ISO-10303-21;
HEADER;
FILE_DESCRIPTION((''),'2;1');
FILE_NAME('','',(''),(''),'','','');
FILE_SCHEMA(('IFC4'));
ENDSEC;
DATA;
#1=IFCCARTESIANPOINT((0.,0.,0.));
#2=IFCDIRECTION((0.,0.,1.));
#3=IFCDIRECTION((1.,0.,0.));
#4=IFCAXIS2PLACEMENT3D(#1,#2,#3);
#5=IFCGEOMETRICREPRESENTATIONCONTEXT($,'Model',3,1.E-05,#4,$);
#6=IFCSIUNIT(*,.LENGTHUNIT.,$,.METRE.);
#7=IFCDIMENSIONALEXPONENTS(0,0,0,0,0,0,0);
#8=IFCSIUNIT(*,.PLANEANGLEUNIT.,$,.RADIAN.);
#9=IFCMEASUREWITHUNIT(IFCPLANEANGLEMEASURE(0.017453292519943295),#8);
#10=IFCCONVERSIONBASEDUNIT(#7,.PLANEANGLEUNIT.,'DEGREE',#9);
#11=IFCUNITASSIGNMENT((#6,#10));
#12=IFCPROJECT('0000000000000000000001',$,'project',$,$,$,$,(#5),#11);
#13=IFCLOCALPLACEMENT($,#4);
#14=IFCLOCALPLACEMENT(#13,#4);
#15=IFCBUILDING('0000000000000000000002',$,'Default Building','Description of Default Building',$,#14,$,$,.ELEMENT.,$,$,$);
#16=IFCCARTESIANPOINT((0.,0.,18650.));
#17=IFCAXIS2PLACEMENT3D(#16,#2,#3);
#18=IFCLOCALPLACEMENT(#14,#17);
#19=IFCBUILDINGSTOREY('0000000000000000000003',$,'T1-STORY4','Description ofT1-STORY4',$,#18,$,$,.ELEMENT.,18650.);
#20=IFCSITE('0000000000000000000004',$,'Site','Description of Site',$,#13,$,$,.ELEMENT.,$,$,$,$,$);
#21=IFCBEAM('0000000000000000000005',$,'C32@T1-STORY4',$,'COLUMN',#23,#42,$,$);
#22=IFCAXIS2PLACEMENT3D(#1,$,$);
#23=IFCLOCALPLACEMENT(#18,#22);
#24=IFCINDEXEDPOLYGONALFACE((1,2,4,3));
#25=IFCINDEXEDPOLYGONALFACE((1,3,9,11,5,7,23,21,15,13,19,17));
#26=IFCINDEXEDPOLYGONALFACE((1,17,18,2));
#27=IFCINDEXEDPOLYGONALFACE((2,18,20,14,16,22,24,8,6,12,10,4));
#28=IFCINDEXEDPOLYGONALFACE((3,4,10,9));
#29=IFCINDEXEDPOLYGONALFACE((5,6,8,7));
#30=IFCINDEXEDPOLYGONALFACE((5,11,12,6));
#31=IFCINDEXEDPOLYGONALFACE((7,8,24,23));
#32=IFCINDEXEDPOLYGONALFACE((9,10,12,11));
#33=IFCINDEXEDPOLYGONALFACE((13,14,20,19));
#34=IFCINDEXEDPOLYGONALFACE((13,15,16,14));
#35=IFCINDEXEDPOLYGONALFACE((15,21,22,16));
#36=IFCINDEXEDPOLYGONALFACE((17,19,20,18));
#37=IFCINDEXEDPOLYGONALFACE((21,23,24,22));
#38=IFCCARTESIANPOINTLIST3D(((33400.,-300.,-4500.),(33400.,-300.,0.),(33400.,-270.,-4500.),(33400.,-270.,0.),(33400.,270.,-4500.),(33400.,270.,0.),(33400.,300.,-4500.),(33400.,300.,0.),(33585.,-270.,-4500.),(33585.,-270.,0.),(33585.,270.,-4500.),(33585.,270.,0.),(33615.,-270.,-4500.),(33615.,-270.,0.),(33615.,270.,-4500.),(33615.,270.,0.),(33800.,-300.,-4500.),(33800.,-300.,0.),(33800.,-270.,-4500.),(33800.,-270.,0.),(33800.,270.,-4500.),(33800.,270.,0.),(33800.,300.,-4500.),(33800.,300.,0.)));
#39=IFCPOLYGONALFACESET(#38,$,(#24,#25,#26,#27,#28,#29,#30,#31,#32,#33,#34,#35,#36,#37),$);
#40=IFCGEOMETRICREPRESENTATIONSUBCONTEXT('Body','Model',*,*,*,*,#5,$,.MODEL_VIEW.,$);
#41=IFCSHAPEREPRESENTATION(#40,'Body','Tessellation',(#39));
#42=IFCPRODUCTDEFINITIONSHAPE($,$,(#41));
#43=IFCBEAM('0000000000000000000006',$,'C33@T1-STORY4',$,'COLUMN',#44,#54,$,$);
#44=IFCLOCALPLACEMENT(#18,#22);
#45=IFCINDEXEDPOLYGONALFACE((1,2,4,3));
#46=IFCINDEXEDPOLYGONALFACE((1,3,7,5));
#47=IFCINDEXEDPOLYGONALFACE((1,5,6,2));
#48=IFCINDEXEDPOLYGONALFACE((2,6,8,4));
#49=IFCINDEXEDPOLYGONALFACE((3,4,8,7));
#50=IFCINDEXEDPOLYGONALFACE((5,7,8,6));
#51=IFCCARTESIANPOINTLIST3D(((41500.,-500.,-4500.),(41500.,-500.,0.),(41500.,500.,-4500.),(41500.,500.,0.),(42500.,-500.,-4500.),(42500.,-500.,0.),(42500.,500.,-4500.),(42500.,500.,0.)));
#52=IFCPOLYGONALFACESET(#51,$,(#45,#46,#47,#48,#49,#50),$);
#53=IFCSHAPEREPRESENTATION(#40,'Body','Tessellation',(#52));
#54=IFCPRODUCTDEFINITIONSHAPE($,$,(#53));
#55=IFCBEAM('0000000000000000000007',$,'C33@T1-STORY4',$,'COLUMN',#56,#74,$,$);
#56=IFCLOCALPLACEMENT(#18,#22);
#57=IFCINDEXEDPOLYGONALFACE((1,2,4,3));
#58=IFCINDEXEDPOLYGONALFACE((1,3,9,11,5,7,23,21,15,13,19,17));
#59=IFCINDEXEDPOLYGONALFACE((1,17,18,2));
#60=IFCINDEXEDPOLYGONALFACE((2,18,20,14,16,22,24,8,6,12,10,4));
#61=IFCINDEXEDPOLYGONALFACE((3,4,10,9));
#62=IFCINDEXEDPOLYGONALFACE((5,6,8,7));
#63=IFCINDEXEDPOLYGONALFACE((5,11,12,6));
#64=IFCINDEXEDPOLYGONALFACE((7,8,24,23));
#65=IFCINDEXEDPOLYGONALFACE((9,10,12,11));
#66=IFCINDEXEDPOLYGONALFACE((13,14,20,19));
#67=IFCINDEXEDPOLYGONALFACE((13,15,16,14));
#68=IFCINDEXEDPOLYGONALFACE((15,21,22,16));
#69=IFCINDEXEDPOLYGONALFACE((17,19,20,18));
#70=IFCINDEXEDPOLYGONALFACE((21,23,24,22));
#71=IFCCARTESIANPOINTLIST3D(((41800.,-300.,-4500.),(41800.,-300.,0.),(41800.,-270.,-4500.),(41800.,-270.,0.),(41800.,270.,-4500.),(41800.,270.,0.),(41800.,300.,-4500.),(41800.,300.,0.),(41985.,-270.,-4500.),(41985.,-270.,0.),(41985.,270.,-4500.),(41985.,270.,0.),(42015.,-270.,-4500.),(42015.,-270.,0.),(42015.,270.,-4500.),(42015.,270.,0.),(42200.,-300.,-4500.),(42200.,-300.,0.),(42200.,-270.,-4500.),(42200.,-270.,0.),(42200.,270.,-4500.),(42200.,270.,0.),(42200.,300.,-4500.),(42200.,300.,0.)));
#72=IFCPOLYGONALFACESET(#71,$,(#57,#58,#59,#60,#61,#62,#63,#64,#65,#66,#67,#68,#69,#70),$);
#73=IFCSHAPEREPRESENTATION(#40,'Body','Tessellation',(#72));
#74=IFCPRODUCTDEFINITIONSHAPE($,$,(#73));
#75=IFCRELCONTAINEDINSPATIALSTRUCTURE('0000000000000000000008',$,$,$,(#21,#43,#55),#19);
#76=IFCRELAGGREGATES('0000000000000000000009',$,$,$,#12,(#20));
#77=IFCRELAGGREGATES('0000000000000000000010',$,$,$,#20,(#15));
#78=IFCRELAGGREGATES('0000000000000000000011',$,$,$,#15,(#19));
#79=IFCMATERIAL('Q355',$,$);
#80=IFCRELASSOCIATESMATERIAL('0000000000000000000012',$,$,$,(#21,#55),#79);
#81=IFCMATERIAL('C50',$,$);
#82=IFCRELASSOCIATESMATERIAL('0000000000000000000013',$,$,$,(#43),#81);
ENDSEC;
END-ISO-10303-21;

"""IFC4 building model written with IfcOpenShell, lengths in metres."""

from ifc_helpers import new_model, entity, si_unit, converted_unit, frame, origin_with_axes, place, context, subcontext, project, spatial, rectangle, i_section, extrude, material, element, save


model = new_model("IFC4")

# Units and contexts
model_context = context("Model", 3, precision=1e-05, world=origin_with_axes())
body_context = subcontext(model_context, "Body", "Model", "MODEL_VIEW")
ifc_project = project(units=[si_unit("LENGTHUNIT", "METRE"), converted_unit("PLANEANGLEUNIT", "DEGREE", entity("IfcPlaneAngleMeasure", 0.017453292519943295), si_unit("PLANEANGLEUNIT", "RADIAN"), dimensions=[0, 0, 0, 0, 0, 0, 0])], contexts=[model_context])

# Site, building, storey
site_placement = place(None, origin_with_axes())
site = spatial("IfcSite", under=ifc_project, at=site_placement, Name="Site", Description="Description of Site", CompositionType="ELEMENT")
building_placement = place(site_placement, origin_with_axes())
building = spatial("IfcBuilding", under=site, at=building_placement, Name="Default Building", Description="Description of Default Building", CompositionType="ELEMENT")
storey_placement = place(building_placement, frame((0.0, 0.0, 18650.0), z_axis=(0.0, 0.0, 1.0), x_axis=(1.0, 0.0, 0.0)))
storey = spatial("IfcBuildingStorey", under=building, at=storey_placement, Name="T1-STORY4", Description="Description ofT1-STORY4", CompositionType="ELEMENT", Elevation=18650.0)

# Beams
ifc_material_1 = material(Name="C50")
ifc_material_2 = material(Name="Q355")
beam_1_placement = place(storey_placement, frame((33600.0, 0.0, -4500.0), z_axis=(0.0, 0.0, 1.0), x_axis=(-1.0, 0.0, 0.0)))
element("IfcBeam", 1, at=beam_1_placement, inside=storey, material=ifc_material_2, Name="C32@T1-STORY4", ObjectType="COLUMN", context=body_context, shape_type="SweptSolid", body=[
    extrude(i_section(OverallWidth=400.0, OverallDepth=600.0, WebThickness=30.0, FlangeThickness=30.0, FilletRadius=0.0), origin_with_axes(), (0.0, 0.0, 1.0), 4500.0),
])
beam_2_placement = place(storey_placement, frame((42000.0, 0.0, -4500.0), z_axis=(0.0, 0.0, 1.0), x_axis=(-1.0, 0.0, 0.0)))
element("IfcBeam", 2, at=beam_2_placement, inside=storey, material=ifc_material_1, Name="C33@T1-STORY4", ObjectType="COLUMN", context=body_context, shape_type="SweptSolid", body=[
    extrude(rectangle(XDim=1000.0, YDim=1000.0), origin_with_axes(), (0.0, 0.0, 1.0), 4500.0),
])
beam_3_placement = place(storey_placement, frame((42000.0, 0.0, -4500.0), z_axis=(0.0, 0.0, 1.0), x_axis=(-1.0, 0.0, 0.0)))
element("IfcBeam", 3, at=beam_3_placement, inside=storey, material=ifc_material_2, Name="C33@T1-STORY4", ObjectType="COLUMN", context=body_context, shape_type="SweptSolid", body=[
    extrude(i_section(OverallWidth=400.0, OverallDepth=600.0, WebThickness=30.0, FlangeThickness=30.0, FilletRadius=0.0), origin_with_axes(), (0.0, 0.0, 1.0), 4500.0),
])

save(model, "model.ifc")
